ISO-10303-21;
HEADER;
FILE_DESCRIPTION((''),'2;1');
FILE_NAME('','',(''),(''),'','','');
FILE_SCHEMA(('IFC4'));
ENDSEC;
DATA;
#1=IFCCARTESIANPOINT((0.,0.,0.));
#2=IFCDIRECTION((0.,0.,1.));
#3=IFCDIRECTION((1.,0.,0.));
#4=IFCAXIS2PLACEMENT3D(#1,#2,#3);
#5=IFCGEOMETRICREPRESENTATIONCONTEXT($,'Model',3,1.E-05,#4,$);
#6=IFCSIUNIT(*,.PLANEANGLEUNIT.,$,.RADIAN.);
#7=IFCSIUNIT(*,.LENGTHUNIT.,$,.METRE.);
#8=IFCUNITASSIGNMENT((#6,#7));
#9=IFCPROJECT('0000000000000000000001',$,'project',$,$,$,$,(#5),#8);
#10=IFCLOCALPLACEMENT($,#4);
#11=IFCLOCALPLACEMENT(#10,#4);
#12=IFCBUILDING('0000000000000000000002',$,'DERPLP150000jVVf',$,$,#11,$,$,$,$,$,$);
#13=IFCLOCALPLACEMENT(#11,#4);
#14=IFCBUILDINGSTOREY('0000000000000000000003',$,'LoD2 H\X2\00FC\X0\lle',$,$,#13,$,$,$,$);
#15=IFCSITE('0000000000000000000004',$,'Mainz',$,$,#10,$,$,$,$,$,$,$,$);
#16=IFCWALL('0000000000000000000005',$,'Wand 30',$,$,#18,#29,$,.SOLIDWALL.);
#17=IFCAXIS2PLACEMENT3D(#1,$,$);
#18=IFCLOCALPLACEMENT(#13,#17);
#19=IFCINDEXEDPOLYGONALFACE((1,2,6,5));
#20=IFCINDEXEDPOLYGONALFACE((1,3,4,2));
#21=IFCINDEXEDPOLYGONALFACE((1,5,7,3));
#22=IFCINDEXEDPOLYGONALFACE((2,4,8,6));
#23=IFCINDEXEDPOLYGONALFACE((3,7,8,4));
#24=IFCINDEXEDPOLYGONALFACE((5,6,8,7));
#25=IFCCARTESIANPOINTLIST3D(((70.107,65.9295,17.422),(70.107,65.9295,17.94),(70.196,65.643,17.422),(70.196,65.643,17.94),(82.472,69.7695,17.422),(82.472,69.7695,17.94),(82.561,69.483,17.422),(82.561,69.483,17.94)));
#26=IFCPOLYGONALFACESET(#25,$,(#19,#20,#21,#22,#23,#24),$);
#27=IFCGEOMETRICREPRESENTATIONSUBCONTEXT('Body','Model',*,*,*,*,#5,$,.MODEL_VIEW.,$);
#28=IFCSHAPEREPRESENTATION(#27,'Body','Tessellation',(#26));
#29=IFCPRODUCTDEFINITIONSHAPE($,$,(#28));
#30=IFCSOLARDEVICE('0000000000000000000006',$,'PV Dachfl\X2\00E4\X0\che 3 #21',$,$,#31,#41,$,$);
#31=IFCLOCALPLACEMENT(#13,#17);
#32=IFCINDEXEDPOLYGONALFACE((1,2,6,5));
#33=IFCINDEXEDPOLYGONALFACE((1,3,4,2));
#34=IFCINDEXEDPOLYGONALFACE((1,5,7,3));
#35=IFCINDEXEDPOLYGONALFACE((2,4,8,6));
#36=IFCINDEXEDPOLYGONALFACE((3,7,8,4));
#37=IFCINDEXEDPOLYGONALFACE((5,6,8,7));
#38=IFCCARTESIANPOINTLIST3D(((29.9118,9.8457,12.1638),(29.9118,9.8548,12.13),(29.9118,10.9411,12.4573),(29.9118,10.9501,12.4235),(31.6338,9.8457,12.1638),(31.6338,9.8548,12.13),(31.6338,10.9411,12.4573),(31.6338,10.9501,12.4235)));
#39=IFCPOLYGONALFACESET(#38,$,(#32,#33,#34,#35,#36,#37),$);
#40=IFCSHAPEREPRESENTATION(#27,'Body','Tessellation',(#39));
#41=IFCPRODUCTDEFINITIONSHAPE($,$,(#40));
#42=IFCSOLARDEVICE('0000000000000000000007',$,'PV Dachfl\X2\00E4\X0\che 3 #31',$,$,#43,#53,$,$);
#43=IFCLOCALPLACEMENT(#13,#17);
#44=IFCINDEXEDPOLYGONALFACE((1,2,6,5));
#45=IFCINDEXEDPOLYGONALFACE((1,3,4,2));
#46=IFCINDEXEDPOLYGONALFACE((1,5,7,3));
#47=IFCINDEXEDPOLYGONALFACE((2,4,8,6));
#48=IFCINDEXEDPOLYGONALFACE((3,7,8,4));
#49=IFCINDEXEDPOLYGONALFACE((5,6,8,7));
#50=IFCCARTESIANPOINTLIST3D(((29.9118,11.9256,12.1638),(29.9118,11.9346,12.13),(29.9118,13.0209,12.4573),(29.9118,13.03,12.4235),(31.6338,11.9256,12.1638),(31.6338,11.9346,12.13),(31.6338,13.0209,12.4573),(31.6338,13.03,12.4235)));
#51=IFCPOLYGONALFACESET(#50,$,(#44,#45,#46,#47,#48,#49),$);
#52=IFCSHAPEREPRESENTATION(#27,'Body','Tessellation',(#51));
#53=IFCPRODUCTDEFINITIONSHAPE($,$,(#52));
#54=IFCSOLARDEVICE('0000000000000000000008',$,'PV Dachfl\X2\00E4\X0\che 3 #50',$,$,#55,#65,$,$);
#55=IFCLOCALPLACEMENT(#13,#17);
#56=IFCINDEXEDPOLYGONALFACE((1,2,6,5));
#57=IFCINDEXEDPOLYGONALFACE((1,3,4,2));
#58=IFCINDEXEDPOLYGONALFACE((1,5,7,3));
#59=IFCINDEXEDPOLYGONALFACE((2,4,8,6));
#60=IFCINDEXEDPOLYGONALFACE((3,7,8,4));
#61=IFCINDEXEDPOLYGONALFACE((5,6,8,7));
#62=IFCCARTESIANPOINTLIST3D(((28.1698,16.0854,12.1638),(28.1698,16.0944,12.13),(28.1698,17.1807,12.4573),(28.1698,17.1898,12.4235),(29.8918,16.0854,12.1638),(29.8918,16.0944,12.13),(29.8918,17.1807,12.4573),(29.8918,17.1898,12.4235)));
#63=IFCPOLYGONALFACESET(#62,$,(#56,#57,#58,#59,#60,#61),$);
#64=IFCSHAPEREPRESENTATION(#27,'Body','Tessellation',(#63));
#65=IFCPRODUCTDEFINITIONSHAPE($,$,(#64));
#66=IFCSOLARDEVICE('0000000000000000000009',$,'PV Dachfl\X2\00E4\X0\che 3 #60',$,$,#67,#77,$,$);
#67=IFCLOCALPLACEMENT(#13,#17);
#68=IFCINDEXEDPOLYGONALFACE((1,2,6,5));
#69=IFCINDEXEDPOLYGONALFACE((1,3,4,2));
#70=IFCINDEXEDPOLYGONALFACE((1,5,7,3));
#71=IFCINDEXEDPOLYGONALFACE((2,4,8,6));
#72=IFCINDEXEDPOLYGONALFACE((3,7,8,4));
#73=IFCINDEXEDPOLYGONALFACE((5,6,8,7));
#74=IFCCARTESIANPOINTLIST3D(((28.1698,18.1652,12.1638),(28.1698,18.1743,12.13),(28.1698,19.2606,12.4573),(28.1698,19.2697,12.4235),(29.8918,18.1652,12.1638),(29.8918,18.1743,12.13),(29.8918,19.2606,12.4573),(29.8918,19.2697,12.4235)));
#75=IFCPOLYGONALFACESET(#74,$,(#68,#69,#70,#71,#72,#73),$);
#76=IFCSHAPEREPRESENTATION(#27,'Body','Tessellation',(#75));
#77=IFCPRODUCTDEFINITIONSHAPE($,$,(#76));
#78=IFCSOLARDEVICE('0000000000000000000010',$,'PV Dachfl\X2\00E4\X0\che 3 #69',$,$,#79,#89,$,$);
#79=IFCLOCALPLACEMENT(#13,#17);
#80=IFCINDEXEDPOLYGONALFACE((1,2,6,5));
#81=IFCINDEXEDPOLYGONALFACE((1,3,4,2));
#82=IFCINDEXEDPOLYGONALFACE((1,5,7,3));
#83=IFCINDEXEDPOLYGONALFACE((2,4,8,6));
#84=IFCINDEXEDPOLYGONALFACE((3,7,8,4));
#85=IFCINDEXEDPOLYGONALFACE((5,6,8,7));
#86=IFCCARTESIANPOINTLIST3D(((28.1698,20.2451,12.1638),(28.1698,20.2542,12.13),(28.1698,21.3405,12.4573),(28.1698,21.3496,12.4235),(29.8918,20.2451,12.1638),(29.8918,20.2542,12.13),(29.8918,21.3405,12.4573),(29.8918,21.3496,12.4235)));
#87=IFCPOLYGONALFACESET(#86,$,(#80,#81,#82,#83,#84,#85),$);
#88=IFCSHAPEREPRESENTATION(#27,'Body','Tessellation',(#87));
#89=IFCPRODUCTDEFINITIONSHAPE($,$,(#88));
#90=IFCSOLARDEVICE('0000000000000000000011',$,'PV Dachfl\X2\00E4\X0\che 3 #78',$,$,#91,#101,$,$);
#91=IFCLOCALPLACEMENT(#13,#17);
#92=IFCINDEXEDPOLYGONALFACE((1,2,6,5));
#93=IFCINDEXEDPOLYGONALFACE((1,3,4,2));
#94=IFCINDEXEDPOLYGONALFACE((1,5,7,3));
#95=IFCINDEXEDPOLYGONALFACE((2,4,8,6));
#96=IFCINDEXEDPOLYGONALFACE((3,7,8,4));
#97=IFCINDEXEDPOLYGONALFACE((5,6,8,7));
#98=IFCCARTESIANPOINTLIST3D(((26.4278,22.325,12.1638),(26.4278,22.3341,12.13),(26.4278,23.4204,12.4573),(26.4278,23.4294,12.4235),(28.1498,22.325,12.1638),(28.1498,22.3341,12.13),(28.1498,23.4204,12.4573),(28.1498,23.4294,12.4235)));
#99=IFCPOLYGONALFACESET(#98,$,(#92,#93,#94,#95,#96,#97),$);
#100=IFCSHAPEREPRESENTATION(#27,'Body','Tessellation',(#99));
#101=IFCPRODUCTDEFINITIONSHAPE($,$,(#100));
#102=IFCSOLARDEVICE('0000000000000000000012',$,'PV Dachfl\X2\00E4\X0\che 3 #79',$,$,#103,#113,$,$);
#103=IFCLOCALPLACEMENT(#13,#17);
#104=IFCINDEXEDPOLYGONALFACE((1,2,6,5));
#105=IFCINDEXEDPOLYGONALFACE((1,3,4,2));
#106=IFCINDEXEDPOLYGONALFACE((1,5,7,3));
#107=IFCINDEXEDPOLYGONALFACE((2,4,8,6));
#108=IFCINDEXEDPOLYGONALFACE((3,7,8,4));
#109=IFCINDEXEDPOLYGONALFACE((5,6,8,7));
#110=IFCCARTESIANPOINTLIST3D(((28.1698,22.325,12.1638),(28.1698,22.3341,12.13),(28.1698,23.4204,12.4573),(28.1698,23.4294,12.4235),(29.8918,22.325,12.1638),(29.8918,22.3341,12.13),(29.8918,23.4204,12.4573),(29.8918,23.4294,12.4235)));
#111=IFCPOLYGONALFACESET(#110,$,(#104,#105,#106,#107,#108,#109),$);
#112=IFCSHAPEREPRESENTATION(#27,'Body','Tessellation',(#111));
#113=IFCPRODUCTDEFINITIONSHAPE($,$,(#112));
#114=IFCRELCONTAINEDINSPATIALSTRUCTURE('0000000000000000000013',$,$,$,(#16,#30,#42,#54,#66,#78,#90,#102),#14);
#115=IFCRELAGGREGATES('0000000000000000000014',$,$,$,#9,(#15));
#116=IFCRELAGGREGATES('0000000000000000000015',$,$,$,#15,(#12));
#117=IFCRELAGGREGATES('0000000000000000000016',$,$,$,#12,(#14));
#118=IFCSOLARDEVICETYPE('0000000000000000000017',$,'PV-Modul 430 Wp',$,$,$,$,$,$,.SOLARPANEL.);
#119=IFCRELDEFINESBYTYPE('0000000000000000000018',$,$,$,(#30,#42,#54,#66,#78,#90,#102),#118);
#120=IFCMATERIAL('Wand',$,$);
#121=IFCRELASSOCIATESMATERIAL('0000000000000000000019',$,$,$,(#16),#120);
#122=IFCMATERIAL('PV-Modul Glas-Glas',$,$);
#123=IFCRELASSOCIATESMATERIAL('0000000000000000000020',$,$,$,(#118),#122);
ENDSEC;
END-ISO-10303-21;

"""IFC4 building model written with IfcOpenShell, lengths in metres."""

from ifc_helpers import new_model, si_unit, frame, frame_2d, origin, origin_with_axes, place, context, subcontext, project, spatial, polyline, rectangle, outline, extrude, source, transform, mapped, material, type_object, type_shapes, element, save


model = new_model("IFC4")

# Units and contexts
model_context = context("Model", 3, precision=1e-05, world=origin_with_axes())
body_context = subcontext(model_context, "Body", "Model", "MODEL_VIEW")
ifc_project = project(units=[si_unit("PLANEANGLEUNIT", "RADIAN"), si_unit("LENGTHUNIT", "METRE")], contexts=[model_context])

# Site, building, storey
site_placement = place(None, origin_with_axes())
site = spatial("IfcSite", under=ifc_project, at=site_placement, Name="Mainz")
building_placement = place(site_placement, origin_with_axes())
building = spatial("IfcBuilding", under=site, at=building_placement, Name="DERPLP150000jVVf")
storey_placement = place(building_placement, origin_with_axes())
storey = spatial("IfcBuildingStorey", under=building, at=storey_placement, Name="LoD2 Hülle")

# Wall
ifc_material_1 = material(Name="Wand")
wall_1_placement = place(storey_placement, origin_with_axes())
element("IfcWall", 1, at=wall_1_placement, inside=storey, material=ifc_material_1, Name="Wand 30", PredefinedType="SOLIDWALL", context=body_context, shape_type="SweptSolid", body=[
    extrude(outline(polyline([(0.0, 0.0), (12.9475, 0.0), (12.9475, 0.518), (0.0, 0.518), (0.0, 0.0)])), frame((70.196, 65.643, 17.422), z_axis=(0.296581, -0.955008, 0.0), x_axis=(0.955008, 0.296581, 0.0)), (0.0, 0.0, -1.0), 0.3),
])

# Solar devices
ifc_material_2 = material(Name="PV-Modul Glas-Glas")
solar_device_type = type_object("IfcSolarDeviceType", Name="PV-Modul 430 Wp", PredefinedType="SOLARPANEL", material=ifc_material_2)
shared_shape = source(origin_with_axes(), body_context, "Body", "SweptSolid", [
    extrude(rectangle(XDim=1.722, YDim=1.134, at=frame_2d((0.861, 0.567))), origin(), (0.0, 0.0, 1.0), 0.035),
])
type_shapes(solar_device_type, [shared_shape])
for number, where, z_axis, x_axis, name in (
    (2, (29.9118, 9.8548, 12.13), (0.0, -0.258819, 0.965926), (1.0, 0.0, 0.0), "PV Dachfläche 3 #21"),
    (3, (29.9118, 11.9346, 12.13), (0.0, -0.258819, 0.965926), (1.0, 0.0, 0.0), "PV Dachfläche 3 #31"),
    (4, (28.1698, 16.0944, 12.13), (0.0, -0.258819, 0.965926), (1.0, 0.0, 0.0), "PV Dachfläche 3 #50"),
    (5, (28.1698, 18.1743, 12.13), (0.0, -0.258819, 0.965926), (1.0, 0.0, 0.0), "PV Dachfläche 3 #60"),
    (6, (28.1698, 20.2542, 12.13), (0.0, -0.258819, 0.965926), (1.0, 0.0, 0.0), "PV Dachfläche 3 #69"),
    (7, (26.4278, 22.3341, 12.13), (0.0, -0.258819, 0.965926), (1.0, 0.0, 0.0), "PV Dachfläche 3 #78"),
    (8, (28.1698, 22.3341, 12.13), (0.0, -0.258819, 0.965926), (1.0, 0.0, 0.0), "PV Dachfläche 3 #79"),
):
    element("IfcSolarDevice", number, at=place(storey_placement, frame(where, z_axis=z_axis, x_axis=x_axis)), inside=storey, type_object=solar_device_type, Name=name, context=body_context, shape_type="MappedRepresentation", body=[
        mapped(shared_shape, transform((0.0, 0.0, 0.0), x_axis=(1.0, 0.0, 0.0), y_axis=(0.0, 1.0, 0.0), z_axis=(0.0, 0.0, 1.0), scale=1.0)),
    ])

save(model, "model.ifc")
